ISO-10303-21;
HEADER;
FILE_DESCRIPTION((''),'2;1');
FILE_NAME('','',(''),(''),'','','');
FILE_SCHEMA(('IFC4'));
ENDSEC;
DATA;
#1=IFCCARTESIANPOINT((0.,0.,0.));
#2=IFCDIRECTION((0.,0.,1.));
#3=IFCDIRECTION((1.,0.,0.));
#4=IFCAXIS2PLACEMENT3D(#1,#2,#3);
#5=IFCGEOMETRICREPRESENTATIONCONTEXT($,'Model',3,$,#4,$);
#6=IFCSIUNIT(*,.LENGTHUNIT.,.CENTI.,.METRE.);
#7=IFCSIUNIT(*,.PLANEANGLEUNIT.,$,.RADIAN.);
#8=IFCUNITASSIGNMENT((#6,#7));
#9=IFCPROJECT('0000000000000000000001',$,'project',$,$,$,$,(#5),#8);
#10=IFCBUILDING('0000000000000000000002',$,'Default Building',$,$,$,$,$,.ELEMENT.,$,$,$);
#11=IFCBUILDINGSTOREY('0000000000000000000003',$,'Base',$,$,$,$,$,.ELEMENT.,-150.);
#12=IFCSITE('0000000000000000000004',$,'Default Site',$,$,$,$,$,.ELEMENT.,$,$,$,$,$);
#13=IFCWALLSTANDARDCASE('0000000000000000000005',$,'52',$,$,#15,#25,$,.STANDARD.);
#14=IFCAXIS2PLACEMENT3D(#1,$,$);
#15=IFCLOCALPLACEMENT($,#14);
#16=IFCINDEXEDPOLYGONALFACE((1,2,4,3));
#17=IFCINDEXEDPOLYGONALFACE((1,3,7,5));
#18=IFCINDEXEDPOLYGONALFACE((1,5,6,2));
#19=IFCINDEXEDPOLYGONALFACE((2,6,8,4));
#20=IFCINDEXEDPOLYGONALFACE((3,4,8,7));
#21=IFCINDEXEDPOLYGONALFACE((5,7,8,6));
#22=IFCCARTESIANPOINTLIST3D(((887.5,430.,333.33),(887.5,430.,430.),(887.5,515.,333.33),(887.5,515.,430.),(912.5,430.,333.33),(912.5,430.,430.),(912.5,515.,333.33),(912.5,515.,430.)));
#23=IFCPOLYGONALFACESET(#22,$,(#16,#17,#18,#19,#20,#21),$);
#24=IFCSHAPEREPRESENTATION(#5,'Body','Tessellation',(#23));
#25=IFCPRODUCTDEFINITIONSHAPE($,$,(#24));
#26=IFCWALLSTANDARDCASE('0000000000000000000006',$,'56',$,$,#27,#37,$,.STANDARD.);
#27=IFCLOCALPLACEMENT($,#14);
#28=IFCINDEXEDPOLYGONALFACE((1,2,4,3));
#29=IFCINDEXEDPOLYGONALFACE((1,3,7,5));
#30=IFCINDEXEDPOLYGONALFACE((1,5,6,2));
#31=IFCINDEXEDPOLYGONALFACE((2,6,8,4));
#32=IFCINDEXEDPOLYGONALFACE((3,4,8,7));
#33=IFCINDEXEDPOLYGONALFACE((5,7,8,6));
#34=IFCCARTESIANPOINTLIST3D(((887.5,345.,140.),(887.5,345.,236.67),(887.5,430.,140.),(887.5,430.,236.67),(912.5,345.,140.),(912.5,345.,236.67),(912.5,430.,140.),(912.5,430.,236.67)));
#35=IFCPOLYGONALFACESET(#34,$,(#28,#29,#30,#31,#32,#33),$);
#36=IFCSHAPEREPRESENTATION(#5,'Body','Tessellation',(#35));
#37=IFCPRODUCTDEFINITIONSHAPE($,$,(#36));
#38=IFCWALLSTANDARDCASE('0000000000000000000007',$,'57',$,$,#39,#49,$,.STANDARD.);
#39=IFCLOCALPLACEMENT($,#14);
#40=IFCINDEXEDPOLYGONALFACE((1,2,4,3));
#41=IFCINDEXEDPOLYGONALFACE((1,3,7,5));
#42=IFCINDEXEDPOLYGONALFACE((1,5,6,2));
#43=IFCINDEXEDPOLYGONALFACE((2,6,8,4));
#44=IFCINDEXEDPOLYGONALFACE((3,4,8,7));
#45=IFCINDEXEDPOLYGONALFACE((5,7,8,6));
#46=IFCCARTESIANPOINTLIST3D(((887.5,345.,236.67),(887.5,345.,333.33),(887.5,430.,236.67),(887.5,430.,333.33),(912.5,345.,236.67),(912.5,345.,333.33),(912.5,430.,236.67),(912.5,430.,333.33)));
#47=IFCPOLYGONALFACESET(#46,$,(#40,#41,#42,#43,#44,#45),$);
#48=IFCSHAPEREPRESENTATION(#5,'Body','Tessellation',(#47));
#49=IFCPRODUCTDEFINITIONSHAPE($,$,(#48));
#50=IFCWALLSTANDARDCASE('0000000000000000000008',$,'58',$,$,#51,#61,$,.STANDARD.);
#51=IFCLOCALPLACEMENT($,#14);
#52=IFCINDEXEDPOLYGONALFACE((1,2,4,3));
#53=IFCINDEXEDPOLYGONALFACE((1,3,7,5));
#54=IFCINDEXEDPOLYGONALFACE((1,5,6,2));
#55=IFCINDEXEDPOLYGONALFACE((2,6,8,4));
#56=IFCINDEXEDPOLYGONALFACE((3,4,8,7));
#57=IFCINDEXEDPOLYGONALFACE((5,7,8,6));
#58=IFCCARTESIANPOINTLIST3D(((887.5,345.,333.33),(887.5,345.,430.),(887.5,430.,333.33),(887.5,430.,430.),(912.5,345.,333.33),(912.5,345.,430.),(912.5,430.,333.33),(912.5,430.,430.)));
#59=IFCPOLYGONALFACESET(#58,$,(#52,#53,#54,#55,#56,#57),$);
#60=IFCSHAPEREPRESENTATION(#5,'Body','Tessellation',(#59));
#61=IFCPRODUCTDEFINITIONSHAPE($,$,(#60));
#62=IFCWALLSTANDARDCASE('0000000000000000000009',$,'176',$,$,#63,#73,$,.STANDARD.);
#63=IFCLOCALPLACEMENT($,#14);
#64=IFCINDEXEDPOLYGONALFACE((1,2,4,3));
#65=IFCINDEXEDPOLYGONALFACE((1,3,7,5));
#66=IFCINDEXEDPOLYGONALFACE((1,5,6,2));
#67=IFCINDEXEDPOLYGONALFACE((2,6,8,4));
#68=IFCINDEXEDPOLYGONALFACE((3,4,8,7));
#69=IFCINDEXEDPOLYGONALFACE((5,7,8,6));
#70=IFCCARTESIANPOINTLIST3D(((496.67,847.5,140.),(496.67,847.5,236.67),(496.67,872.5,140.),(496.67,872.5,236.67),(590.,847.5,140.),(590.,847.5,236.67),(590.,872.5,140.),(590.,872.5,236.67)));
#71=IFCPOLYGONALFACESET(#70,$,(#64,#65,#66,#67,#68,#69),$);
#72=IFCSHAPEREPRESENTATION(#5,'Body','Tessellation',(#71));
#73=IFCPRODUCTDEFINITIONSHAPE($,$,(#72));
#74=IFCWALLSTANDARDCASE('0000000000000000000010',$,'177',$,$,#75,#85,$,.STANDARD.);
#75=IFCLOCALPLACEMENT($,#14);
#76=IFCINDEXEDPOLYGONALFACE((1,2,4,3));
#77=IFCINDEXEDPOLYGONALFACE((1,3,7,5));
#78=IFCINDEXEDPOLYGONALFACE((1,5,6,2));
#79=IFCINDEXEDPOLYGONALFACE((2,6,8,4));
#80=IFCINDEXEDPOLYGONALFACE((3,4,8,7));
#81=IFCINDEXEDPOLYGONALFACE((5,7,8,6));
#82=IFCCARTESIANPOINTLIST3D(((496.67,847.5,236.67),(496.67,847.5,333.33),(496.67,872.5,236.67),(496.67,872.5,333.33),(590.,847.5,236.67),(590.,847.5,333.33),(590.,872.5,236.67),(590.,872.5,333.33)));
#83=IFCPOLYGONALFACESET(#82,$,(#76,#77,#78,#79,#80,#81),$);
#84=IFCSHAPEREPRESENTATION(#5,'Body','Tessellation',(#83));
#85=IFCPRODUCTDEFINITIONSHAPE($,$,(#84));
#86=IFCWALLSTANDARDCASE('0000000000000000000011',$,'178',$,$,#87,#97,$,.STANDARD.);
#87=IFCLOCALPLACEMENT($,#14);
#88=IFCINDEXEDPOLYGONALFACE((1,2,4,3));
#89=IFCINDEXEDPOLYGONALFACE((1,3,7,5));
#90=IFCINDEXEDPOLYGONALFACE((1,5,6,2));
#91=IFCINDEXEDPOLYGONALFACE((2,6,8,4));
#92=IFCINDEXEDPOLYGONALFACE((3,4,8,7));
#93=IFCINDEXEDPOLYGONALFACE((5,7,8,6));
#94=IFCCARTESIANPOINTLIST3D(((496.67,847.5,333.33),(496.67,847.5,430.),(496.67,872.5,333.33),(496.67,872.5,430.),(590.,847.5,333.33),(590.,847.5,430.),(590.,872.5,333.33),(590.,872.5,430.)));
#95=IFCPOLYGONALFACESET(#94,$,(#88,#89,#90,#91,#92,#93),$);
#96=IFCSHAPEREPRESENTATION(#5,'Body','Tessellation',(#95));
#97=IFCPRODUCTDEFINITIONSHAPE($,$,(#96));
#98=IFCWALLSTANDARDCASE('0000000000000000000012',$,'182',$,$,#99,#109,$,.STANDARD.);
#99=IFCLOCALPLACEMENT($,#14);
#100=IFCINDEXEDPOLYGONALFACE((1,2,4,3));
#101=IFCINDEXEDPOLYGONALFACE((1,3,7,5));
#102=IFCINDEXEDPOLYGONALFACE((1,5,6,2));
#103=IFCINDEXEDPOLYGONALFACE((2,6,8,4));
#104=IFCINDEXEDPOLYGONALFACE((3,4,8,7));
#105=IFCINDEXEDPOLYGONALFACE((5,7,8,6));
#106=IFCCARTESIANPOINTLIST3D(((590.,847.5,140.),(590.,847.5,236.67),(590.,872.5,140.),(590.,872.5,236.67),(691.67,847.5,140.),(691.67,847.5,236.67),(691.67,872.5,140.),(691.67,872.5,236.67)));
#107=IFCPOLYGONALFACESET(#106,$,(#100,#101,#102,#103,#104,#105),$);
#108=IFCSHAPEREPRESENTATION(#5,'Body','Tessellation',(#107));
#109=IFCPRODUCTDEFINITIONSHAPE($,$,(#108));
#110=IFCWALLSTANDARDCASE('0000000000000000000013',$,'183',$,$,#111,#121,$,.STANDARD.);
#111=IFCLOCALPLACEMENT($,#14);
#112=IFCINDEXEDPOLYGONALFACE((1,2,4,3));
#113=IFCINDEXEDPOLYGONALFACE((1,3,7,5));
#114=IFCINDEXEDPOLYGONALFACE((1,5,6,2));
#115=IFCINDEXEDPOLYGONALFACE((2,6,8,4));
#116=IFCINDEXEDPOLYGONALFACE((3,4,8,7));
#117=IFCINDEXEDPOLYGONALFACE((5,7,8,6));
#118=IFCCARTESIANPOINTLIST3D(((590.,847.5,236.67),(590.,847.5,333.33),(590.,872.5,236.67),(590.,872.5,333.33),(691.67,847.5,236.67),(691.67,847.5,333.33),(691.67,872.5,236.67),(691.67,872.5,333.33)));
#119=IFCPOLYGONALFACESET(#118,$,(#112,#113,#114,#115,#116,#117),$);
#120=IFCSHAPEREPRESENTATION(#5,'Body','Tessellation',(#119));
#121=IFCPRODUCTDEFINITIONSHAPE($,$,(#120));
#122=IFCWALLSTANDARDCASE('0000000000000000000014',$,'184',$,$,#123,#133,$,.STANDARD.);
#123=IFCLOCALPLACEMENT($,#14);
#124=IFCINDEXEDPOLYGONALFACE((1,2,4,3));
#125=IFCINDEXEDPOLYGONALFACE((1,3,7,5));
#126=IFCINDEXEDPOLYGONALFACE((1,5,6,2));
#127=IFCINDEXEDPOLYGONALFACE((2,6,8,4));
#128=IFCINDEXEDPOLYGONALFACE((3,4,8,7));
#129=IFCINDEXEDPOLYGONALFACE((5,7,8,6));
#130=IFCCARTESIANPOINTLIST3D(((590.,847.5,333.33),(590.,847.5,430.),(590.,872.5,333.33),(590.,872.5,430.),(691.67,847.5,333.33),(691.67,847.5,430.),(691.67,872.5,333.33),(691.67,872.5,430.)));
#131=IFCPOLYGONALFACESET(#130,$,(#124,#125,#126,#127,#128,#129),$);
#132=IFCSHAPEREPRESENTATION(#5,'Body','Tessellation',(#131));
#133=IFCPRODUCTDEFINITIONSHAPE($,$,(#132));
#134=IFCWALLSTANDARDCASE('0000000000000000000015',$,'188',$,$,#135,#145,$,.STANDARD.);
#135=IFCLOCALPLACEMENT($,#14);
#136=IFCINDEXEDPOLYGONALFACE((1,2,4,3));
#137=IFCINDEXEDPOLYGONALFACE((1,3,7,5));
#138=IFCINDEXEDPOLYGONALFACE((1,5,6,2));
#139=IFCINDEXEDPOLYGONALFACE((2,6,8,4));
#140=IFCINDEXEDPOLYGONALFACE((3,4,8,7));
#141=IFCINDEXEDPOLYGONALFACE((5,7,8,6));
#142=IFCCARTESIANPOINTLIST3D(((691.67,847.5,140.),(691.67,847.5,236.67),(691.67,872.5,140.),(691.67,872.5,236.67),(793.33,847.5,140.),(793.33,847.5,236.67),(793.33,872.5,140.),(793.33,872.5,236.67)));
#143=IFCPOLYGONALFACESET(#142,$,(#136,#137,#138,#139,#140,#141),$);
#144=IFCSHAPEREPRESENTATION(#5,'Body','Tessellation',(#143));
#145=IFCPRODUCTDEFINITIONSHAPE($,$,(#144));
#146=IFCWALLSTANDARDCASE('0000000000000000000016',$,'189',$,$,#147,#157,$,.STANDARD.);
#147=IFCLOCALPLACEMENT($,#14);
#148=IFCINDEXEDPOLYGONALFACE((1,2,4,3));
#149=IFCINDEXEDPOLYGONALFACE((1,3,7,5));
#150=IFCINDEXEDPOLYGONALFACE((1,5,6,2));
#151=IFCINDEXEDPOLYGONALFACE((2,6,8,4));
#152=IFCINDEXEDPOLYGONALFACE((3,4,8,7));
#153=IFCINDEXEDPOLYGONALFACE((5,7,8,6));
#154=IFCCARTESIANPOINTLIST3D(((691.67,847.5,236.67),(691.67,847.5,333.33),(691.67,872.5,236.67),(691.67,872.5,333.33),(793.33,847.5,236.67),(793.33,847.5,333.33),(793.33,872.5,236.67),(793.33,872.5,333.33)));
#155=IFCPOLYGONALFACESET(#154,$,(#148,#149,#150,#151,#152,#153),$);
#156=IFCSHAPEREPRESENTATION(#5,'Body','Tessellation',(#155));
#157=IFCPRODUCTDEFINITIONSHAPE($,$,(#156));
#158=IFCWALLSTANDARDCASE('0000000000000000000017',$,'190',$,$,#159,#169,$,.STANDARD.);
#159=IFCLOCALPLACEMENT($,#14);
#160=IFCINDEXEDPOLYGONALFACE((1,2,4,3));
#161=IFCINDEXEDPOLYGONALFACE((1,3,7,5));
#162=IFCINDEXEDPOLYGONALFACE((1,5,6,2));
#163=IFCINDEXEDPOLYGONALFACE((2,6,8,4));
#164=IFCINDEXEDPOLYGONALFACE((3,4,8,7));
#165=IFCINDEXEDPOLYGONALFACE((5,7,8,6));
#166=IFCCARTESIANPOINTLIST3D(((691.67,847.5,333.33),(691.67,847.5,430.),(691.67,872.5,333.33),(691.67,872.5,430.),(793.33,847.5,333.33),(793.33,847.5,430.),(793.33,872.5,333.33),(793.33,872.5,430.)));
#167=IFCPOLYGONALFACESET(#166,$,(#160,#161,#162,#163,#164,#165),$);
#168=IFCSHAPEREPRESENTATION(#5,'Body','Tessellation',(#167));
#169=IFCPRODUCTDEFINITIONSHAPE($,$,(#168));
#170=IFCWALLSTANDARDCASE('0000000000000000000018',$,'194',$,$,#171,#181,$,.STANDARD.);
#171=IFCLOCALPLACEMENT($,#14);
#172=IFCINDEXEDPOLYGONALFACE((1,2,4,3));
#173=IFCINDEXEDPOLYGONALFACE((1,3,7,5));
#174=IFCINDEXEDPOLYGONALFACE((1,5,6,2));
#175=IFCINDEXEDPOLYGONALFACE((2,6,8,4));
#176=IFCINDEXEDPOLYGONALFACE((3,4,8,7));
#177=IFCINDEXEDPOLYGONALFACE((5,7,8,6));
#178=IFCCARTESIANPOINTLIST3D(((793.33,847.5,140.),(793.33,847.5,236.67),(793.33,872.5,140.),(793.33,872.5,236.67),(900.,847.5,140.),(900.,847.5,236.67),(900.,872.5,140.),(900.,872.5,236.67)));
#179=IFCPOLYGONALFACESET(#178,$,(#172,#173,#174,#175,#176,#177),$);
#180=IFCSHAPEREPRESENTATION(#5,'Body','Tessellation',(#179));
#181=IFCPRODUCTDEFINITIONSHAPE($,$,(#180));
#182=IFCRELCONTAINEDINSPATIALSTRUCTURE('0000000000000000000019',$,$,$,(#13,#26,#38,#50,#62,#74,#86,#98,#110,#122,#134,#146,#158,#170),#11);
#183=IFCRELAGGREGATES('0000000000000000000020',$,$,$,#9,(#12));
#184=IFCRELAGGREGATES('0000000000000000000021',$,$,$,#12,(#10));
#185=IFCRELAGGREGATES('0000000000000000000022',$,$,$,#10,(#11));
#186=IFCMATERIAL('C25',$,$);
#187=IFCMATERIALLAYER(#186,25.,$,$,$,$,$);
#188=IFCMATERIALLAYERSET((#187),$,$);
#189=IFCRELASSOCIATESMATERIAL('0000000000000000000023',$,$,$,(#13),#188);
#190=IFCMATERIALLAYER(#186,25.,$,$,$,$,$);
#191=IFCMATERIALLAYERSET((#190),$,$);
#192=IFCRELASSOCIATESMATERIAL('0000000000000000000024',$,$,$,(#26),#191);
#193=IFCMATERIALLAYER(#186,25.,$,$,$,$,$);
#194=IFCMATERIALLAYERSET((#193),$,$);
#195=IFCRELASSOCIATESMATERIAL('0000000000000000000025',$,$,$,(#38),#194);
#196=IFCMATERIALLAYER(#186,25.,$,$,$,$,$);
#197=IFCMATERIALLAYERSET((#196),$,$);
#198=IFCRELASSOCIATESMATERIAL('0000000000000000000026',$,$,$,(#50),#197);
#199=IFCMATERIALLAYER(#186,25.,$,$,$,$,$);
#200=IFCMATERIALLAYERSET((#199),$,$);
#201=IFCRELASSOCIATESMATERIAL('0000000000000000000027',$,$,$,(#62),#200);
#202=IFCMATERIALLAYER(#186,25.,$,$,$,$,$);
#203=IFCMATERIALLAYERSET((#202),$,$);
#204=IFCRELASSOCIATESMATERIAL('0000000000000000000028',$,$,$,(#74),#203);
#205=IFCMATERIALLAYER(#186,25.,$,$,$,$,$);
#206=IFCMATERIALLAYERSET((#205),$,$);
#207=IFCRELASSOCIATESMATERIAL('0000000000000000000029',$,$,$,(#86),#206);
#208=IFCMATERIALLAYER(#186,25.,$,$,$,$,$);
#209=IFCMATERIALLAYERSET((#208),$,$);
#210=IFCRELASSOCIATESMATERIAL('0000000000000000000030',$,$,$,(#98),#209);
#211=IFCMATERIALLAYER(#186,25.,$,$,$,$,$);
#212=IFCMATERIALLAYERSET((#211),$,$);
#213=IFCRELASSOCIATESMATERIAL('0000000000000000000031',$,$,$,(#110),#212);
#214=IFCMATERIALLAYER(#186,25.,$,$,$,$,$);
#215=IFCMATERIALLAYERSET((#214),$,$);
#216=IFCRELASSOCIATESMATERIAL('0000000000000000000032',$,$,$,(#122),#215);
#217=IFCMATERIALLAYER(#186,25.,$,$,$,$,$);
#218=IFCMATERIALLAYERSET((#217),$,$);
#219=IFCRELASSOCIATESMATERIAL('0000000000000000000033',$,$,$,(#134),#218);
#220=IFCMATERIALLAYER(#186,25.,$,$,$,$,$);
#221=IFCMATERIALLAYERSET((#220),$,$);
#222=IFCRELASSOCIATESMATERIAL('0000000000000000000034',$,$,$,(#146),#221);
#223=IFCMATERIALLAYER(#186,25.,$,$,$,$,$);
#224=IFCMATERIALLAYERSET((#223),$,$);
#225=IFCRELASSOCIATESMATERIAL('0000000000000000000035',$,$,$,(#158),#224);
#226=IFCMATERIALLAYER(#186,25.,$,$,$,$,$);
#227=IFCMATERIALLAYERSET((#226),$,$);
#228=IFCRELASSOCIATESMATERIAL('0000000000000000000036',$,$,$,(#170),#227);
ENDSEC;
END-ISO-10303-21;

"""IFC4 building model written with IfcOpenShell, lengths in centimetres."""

from ifc_helpers import new_model, si_unit, frame, origin_with_axes, origin_2d_with_axis, place, context, project, spatial, rectangle, extrude, material, layer, layer_set, layer_usage, element, save


model = new_model("IFC4")

# Units and contexts
model_context = context("Model", 3, world=origin_with_axes())
ifc_project = project(units=[si_unit("LENGTHUNIT", "METRE", prefix="CENTI"), si_unit("PLANEANGLEUNIT", "RADIAN")], contexts=[model_context])

# Site, building, storey
site = spatial("IfcSite", under=ifc_project, Name="Default Site", CompositionType="ELEMENT")
building = spatial("IfcBuilding", under=site, Name="Default Building", CompositionType="ELEMENT")
storey = spatial("IfcBuildingStorey", under=building, Name="Base", CompositionType="ELEMENT", Elevation=-150.0)

# Walls
ifc_material = material(Name="C25")
ifc_layer_1 = layer(ifc_material, 25.0)
ifc_layer_set_1 = layer_set([ifc_layer_1])
ifc_layer_usage_1 = layer_usage(ifc_layer_set_1, "AXIS2", "POSITIVE", -25.0)
wall_1_placement = place(None, frame((900.0, 472.5, 333.33), z_axis=(0.0, 0.0, 1.0), x_axis=(0.0, -1.0, 0.0)))
element("IfcWallStandardCase", 1, at=wall_1_placement, inside=storey, material=ifc_layer_usage_1, Name="52", PredefinedType="STANDARD", context=model_context, shape_type="SweptSolid", body=[
    extrude(rectangle(XDim=85.0, YDim=25.0, at=origin_2d_with_axis()), origin_with_axes(), (0.0, 0.0, 1.0), 96.67),
])
ifc_layer_2 = layer(ifc_material, 25.0)
ifc_layer_set_2 = layer_set([ifc_layer_2])
ifc_layer_usage_2 = layer_usage(ifc_layer_set_2, "AXIS2", "POSITIVE", -25.0)
wall_2_placement = place(None, frame((900.0, 387.5, 140.0), z_axis=(0.0, 0.0, 1.0), x_axis=(0.0, -1.0, 0.0)))
element("IfcWallStandardCase", 2, at=wall_2_placement, inside=storey, material=ifc_layer_usage_2, Name="56", PredefinedType="STANDARD", context=model_context, shape_type="SweptSolid", body=[
    extrude(rectangle(XDim=85.0, YDim=25.0, at=origin_2d_with_axis()), origin_with_axes(), (0.0, 0.0, 1.0), 96.67),
])
ifc_layer_3 = layer(ifc_material, 25.0)
ifc_layer_set_3 = layer_set([ifc_layer_3])
ifc_layer_usage_3 = layer_usage(ifc_layer_set_3, "AXIS2", "POSITIVE", -25.0)
wall_3_placement = place(None, frame((900.0, 387.5, 236.67), z_axis=(0.0, 0.0, 1.0), x_axis=(0.0, -1.0, 0.0)))
element("IfcWallStandardCase", 3, at=wall_3_placement, inside=storey, material=ifc_layer_usage_3, Name="57", PredefinedType="STANDARD", context=model_context, shape_type="SweptSolid", body=[
    extrude(rectangle(XDim=85.0, YDim=25.0, at=origin_2d_with_axis()), origin_with_axes(), (0.0, 0.0, 1.0), 96.67),
])
ifc_layer_4 = layer(ifc_material, 25.0)
ifc_layer_set_4 = layer_set([ifc_layer_4])
ifc_layer_usage_4 = layer_usage(ifc_layer_set_4, "AXIS2", "POSITIVE", -25.0)
wall_4_placement = place(None, frame((900.0, 387.5, 333.33), z_axis=(0.0, 0.0, 1.0), x_axis=(0.0, -1.0, 0.0)))
element("IfcWallStandardCase", 4, at=wall_4_placement, inside=storey, material=ifc_layer_usage_4, Name="58", PredefinedType="STANDARD", context=model_context, shape_type="SweptSolid", body=[
    extrude(rectangle(XDim=85.0, YDim=25.0, at=origin_2d_with_axis()), origin_with_axes(), (0.0, 0.0, 1.0), 96.67),
])
ifc_layer_5 = layer(ifc_material, 25.0)
ifc_layer_set_5 = layer_set([ifc_layer_5])
ifc_layer_usage_5 = layer_usage(ifc_layer_set_5, "AXIS2", "POSITIVE", -25.0)
wall_5_placement = place(None, frame((543.33, 860.0, 140.0), z_axis=(0.0, 0.0, 1.0), x_axis=(1.0, 0.0, 0.0)))
element("IfcWallStandardCase", 5, at=wall_5_placement, inside=storey, material=ifc_layer_usage_5, Name="176", PredefinedType="STANDARD", context=model_context, shape_type="SweptSolid", body=[
    extrude(rectangle(XDim=93.33, YDim=25.0, at=origin_2d_with_axis()), origin_with_axes(), (0.0, 0.0, 1.0), 96.67),
])
ifc_layer_6 = layer(ifc_material, 25.0)
ifc_layer_set_6 = layer_set([ifc_layer_6])
ifc_layer_usage_6 = layer_usage(ifc_layer_set_6, "AXIS2", "POSITIVE", -25.0)
wall_6_placement = place(None, frame((543.33, 860.0, 236.67), z_axis=(0.0, 0.0, 1.0), x_axis=(1.0, 0.0, 0.0)))
element("IfcWallStandardCase", 6, at=wall_6_placement, inside=storey, material=ifc_layer_usage_6, Name="177", PredefinedType="STANDARD", context=model_context, shape_type="SweptSolid", body=[
    extrude(rectangle(XDim=93.33, YDim=25.0, at=origin_2d_with_axis()), origin_with_axes(), (0.0, 0.0, 1.0), 96.67),
])
ifc_layer_7 = layer(ifc_material, 25.0)
ifc_layer_set_7 = layer_set([ifc_layer_7])
ifc_layer_usage_7 = layer_usage(ifc_layer_set_7, "AXIS2", "POSITIVE", -25.0)
wall_7_placement = place(None, frame((543.33, 860.0, 333.33), z_axis=(0.0, 0.0, 1.0), x_axis=(1.0, 0.0, 0.0)))
element("IfcWallStandardCase", 7, at=wall_7_placement, inside=storey, material=ifc_layer_usage_7, Name="178", PredefinedType="STANDARD", context=model_context, shape_type="SweptSolid", body=[
    extrude(rectangle(XDim=93.33, YDim=25.0, at=origin_2d_with_axis()), origin_with_axes(), (0.0, 0.0, 1.0), 96.67),
])
ifc_layer_8 = layer(ifc_material, 25.0)
ifc_layer_set_8 = layer_set([ifc_layer_8])
ifc_layer_usage_8 = layer_usage(ifc_layer_set_8, "AXIS2", "POSITIVE", -25.0)
wall_8_placement = place(None, frame((640.83, 860.0, 140.0), z_axis=(0.0, 0.0, 1.0), x_axis=(1.0, 0.0, 0.0)))
element("IfcWallStandardCase", 8, at=wall_8_placement, inside=storey, material=ifc_layer_usage_8, Name="182", PredefinedType="STANDARD", context=model_context, shape_type="SweptSolid", body=[
    extrude(rectangle(XDim=101.67, YDim=25.0, at=origin_2d_with_axis()), origin_with_axes(), (0.0, 0.0, 1.0), 96.67),
])
ifc_layer_9 = layer(ifc_material, 25.0)
ifc_layer_set_9 = layer_set([ifc_layer_9])
ifc_layer_usage_9 = layer_usage(ifc_layer_set_9, "AXIS2", "POSITIVE", -25.0)
wall_9_placement = place(None, frame((640.83, 860.0, 236.67), z_axis=(0.0, 0.0, 1.0), x_axis=(1.0, 0.0, 0.0)))
element("IfcWallStandardCase", 9, at=wall_9_placement, inside=storey, material=ifc_layer_usage_9, Name="183", PredefinedType="STANDARD", context=model_context, shape_type="SweptSolid", body=[
    extrude(rectangle(XDim=101.67, YDim=25.0, at=origin_2d_with_axis()), origin_with_axes(), (0.0, 0.0, 1.0), 96.67),
])
ifc_layer_10 = layer(ifc_material, 25.0)
ifc_layer_set_10 = layer_set([ifc_layer_10])
ifc_layer_usage_10 = layer_usage(ifc_layer_set_10, "AXIS2", "POSITIVE", -25.0)
wall_10_placement = place(None, frame((640.83, 860.0, 333.33), z_axis=(0.0, 0.0, 1.0), x_axis=(1.0, 0.0, 0.0)))
element("IfcWallStandardCase", 10, at=wall_10_placement, inside=storey, material=ifc_layer_usage_10, Name="184", PredefinedType="STANDARD", context=model_context, shape_type="SweptSolid", body=[
    extrude(rectangle(XDim=101.67, YDim=25.0, at=origin_2d_with_axis()), origin_with_axes(), (0.0, 0.0, 1.0), 96.67),
])
ifc_layer_11 = layer(ifc_material, 25.0)
ifc_layer_set_11 = layer_set([ifc_layer_11])
ifc_layer_usage_11 = layer_usage(ifc_layer_set_11, "AXIS2", "POSITIVE", -25.0)
wall_11_placement = place(None, frame((742.5, 860.0, 140.0), z_axis=(0.0, 0.0, 1.0), x_axis=(1.0, 0.0, 0.0)))
element("IfcWallStandardCase", 11, at=wall_11_placement, inside=storey, material=ifc_layer_usage_11, Name="188", PredefinedType="STANDARD", context=model_context, shape_type="SweptSolid", body=[
    extrude(rectangle(XDim=101.67, YDim=25.0, at=origin_2d_with_axis()), origin_with_axes(), (0.0, 0.0, 1.0), 96.67),
])
ifc_layer_12 = layer(ifc_material, 25.0)
ifc_layer_set_12 = layer_set([ifc_layer_12])
ifc_layer_usage_12 = layer_usage(ifc_layer_set_12, "AXIS2", "POSITIVE", -25.0)
wall_12_placement = place(None, frame((742.5, 860.0, 236.67), z_axis=(0.0, 0.0, 1.0), x_axis=(1.0, 0.0, 0.0)))
element("IfcWallStandardCase", 12, at=wall_12_placement, inside=storey, material=ifc_layer_usage_12, Name="189", PredefinedType="STANDARD", context=model_context, shape_type="SweptSolid", body=[
    extrude(rectangle(XDim=101.67, YDim=25.0, at=origin_2d_with_axis()), origin_with_axes(), (0.0, 0.0, 1.0), 96.67),
])
ifc_layer_13 = layer(ifc_material, 25.0)
ifc_layer_set_13 = layer_set([ifc_layer_13])
ifc_layer_usage_13 = layer_usage(ifc_layer_set_13, "AXIS2", "POSITIVE", -25.0)
wall_13_placement = place(None, frame((742.5, 860.0, 333.33), z_axis=(0.0, 0.0, 1.0), x_axis=(1.0, 0.0, 0.0)))
element("IfcWallStandardCase", 13, at=wall_13_placement, inside=storey, material=ifc_layer_usage_13, Name="190", PredefinedType="STANDARD", context=model_context, shape_type="SweptSolid", body=[
    extrude(rectangle(XDim=101.67, YDim=25.0, at=origin_2d_with_axis()), origin_with_axes(), (0.0, 0.0, 1.0), 96.67),
])
ifc_layer_14 = layer(ifc_material, 25.0)
ifc_layer_set_14 = layer_set([ifc_layer_14])
ifc_layer_usage_14 = layer_usage(ifc_layer_set_14, "AXIS2", "POSITIVE", -25.0)
wall_14_placement = place(None, frame((846.67, 860.0, 140.0), z_axis=(0.0, 0.0, 1.0), x_axis=(1.0, 0.0, 0.0)))
element("IfcWallStandardCase", 14, at=wall_14_placement, inside=storey, material=ifc_layer_usage_14, Name="194", PredefinedType="STANDARD", context=model_context, shape_type="SweptSolid", body=[
    extrude(rectangle(XDim=106.67, YDim=25.0, at=origin_2d_with_axis()), origin_with_axes(), (0.0, 0.0, 1.0), 96.67),
])

save(model, "model.ifc")
